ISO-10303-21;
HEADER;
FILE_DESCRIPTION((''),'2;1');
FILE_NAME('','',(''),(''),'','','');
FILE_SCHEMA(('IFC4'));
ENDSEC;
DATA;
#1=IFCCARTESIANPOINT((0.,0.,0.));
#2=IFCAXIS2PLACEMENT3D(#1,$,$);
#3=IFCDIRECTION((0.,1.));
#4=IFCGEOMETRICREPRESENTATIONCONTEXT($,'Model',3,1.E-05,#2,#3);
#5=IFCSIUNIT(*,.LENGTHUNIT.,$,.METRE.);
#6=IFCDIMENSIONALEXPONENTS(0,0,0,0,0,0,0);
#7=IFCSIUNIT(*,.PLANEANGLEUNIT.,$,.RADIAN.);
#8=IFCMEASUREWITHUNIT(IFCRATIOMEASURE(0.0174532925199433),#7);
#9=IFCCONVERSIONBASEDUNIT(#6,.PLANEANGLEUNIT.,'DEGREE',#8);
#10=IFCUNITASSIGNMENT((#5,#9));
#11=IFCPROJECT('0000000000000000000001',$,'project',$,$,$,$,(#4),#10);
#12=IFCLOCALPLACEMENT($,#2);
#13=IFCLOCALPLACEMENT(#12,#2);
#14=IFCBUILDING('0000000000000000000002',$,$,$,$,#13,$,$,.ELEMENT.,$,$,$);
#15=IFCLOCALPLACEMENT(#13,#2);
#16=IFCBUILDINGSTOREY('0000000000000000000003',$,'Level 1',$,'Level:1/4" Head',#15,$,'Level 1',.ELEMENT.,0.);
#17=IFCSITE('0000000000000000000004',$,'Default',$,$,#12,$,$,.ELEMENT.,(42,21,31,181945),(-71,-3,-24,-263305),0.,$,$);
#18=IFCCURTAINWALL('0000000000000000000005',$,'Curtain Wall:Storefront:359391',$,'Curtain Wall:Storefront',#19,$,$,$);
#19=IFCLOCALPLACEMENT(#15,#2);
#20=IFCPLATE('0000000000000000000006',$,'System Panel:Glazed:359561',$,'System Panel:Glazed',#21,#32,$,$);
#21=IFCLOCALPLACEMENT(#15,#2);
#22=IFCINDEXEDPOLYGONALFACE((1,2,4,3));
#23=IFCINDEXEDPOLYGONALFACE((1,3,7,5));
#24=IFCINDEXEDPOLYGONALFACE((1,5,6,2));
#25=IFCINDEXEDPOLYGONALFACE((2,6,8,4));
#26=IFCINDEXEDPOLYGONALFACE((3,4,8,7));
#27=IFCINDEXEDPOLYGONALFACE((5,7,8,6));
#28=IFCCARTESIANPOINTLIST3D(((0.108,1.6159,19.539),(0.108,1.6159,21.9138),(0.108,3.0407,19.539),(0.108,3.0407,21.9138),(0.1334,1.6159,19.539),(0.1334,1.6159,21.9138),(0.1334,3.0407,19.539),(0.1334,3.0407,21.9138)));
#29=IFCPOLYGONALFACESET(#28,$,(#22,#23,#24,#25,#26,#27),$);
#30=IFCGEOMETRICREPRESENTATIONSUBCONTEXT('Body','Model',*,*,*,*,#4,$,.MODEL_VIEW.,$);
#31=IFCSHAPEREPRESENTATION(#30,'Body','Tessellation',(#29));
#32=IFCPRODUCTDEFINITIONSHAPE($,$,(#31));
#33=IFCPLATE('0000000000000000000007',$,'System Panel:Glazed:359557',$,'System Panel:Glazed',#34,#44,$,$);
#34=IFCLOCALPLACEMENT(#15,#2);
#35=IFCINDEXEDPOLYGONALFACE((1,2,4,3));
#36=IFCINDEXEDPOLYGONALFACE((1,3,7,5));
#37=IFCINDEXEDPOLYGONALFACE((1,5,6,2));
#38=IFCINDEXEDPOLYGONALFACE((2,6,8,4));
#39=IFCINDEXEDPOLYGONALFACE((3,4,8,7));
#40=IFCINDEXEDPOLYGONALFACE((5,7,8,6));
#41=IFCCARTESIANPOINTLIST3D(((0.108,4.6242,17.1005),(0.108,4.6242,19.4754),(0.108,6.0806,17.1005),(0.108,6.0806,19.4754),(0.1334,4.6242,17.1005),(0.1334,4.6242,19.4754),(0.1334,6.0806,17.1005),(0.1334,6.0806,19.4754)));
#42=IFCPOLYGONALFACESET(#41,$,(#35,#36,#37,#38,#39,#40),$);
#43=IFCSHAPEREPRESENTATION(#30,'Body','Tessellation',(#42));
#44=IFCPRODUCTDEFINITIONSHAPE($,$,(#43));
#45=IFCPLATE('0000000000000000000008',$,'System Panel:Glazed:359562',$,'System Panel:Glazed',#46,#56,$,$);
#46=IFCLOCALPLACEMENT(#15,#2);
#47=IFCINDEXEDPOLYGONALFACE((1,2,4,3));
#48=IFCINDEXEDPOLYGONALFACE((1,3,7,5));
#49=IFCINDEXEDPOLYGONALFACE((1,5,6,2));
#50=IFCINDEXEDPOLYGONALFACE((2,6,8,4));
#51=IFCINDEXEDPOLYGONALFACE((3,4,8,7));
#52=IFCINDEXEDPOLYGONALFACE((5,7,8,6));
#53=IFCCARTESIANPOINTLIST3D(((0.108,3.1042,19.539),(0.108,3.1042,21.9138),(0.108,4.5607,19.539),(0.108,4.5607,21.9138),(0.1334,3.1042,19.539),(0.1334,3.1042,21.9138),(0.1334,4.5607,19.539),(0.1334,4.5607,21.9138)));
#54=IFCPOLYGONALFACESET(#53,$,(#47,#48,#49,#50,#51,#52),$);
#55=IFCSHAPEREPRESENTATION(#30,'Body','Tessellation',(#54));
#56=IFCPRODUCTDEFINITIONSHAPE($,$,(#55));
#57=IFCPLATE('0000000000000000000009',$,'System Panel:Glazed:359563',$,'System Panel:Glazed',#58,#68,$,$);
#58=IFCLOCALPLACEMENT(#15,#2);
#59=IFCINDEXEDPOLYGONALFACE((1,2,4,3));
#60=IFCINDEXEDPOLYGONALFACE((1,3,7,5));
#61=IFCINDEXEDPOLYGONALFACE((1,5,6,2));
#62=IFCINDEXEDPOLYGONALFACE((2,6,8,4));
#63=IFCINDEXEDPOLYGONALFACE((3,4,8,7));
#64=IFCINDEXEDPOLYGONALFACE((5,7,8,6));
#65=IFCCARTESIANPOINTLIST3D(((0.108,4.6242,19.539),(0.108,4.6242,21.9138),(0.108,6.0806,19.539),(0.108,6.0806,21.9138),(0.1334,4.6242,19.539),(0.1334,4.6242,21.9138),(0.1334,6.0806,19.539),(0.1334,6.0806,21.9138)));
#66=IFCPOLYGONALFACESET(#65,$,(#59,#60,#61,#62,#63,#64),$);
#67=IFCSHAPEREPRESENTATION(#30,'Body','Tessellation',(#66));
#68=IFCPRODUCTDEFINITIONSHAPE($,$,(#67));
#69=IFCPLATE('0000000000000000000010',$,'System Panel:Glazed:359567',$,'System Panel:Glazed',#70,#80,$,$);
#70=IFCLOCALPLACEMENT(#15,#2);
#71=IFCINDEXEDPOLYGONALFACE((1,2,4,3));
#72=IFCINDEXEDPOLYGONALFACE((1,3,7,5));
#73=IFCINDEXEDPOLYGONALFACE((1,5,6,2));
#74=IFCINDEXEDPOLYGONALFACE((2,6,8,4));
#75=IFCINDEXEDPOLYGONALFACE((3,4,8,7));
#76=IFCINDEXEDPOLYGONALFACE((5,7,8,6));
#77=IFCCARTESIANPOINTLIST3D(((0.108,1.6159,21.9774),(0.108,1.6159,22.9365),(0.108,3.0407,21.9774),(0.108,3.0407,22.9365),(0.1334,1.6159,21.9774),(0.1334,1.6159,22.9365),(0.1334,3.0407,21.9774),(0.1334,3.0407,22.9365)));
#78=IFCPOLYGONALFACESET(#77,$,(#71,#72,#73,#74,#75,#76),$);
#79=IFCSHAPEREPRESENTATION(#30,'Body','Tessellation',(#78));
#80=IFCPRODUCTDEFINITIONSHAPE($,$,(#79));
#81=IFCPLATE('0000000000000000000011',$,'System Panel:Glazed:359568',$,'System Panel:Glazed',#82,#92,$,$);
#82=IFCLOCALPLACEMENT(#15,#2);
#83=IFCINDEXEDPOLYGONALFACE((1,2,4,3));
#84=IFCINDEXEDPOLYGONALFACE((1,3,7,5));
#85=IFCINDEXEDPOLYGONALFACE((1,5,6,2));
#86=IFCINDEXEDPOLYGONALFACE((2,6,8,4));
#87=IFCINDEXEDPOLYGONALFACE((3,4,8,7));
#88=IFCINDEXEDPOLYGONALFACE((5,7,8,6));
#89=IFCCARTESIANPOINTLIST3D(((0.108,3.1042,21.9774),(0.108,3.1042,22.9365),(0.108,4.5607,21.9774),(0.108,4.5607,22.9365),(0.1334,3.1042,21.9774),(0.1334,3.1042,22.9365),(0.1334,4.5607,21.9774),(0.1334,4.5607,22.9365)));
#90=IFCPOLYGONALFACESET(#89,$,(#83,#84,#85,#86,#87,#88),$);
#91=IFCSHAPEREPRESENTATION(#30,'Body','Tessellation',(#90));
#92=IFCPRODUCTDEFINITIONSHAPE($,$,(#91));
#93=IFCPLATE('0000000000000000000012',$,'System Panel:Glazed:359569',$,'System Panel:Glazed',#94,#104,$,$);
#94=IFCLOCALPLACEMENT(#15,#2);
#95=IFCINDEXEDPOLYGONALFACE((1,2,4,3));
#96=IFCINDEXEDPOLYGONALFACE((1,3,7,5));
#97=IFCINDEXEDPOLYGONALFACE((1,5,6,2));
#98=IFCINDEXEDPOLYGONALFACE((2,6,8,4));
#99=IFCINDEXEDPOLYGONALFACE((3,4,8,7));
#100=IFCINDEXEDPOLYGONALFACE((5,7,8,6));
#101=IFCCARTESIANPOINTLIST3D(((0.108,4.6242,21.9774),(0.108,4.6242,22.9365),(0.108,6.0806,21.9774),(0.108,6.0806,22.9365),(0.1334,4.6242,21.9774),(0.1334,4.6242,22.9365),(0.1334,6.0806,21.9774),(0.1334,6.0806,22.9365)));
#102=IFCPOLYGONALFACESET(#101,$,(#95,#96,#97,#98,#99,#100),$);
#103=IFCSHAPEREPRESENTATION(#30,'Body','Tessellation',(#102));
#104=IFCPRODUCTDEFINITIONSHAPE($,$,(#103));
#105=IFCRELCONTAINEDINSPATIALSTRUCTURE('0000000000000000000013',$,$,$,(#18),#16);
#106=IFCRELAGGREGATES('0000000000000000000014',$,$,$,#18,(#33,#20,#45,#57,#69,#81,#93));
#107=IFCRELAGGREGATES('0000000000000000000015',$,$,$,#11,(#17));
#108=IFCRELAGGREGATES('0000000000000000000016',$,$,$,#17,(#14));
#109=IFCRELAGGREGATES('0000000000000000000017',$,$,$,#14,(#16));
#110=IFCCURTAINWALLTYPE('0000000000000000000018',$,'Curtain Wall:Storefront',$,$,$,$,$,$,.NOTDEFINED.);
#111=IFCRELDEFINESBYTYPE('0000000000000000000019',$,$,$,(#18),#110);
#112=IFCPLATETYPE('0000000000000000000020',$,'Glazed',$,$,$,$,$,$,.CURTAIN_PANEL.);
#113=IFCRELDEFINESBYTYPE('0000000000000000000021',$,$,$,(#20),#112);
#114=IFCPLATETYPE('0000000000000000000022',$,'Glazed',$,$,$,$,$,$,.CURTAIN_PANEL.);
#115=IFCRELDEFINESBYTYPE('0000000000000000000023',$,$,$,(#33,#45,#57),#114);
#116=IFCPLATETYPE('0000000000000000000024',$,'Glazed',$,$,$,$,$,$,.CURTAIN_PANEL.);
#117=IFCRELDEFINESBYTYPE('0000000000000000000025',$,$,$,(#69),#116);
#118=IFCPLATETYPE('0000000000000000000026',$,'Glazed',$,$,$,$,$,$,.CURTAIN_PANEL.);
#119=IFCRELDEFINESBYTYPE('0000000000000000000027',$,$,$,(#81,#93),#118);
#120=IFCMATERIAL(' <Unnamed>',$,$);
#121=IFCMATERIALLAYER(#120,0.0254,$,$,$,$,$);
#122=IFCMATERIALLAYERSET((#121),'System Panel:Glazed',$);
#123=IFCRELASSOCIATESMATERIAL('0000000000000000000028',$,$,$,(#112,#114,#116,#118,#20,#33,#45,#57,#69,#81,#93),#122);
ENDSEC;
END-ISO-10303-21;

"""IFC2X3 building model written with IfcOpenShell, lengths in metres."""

from ifc_helpers import new_model, entity, si_unit, converted_unit, direction, frame, frame_2d, origin, place, context, subcontext, project, spatial, rectangle, extrude, source, transform, mapped, material, layer, layer_set, layer_usage, type_object, type_shapes, element, aggregate, save


model = new_model("IFC2X3")

# Units and contexts
model_context = context("Model", 3, precision=1e-05, world=origin(), true_north=direction((0.0, 1.0)))
body_context = subcontext(model_context, "Body", "Model", "MODEL_VIEW")
ifc_project = project(units=[si_unit("LENGTHUNIT", "METRE"), converted_unit("PLANEANGLEUNIT", "DEGREE", entity("IfcRatioMeasure", 0.0174532925199433), si_unit("PLANEANGLEUNIT", "RADIAN"), dimensions=[0, 0, 0, 0, 0, 0, 0])], contexts=[model_context])

# Site, building, storey
site_placement = place(None, origin())
site = spatial("IfcSite", under=ifc_project, at=site_placement, Name="Default", CompositionType="ELEMENT", RefLatitude=(42, 21, 31, 181945), RefLongitude=(-71, -3, -24, -263305), RefElevation=0.0)
building_placement = place(site_placement, origin())
building = spatial("IfcBuilding", under=site, at=building_placement, CompositionType="ELEMENT")
storey_placement = place(building_placement, origin())
storey = spatial("IfcBuildingStorey", under=building, at=storey_placement, Name="Level 1", ObjectType="Level:1/4\" Head", LongName="Level 1", CompositionType="ELEMENT", Elevation=0.0)

# Curtain wall, plates
curtain_wall_type = type_object("IfcCurtainWallType", Name="Curtain Wall:Storefront", PredefinedType="NOTDEFINED")
curtain_wall_placement = place(storey_placement, origin())
curtain_wall = element("IfcCurtainWall", 1, at=curtain_wall_placement, inside=storey, type_object=curtain_wall_type, Name="Curtain Wall:Storefront:359391", ObjectType="Curtain Wall:Storefront")
ifc_material_1 = material(Name=" <Unnamed>")
ifc_layer = layer(ifc_material_1, 0.0254)
ifc_layer_set = layer_set([ifc_layer], Name="System Panel:Glazed")
ifc_layer_usage_1 = layer_usage(ifc_layer_set, "AXIS3", "POSITIVE", 0.1042)
plate_type_1 = type_object("IfcPlateType", Name="Glazed", PredefinedType="CURTAIN_PANEL", material=ifc_layer_set)
shared_shape_1 = source(origin(), body_context, "Body", "SweptSolid", [
    extrude(rectangle(XDim=0.0254, YDim=1.4248, at=frame_2d((0.0, 0.0), x_axis=(1.0, 0.0))), frame((0.7124, 0.0127, 0.0), z_axis=(0.0, 0.0, 1.0), x_axis=(0.0, 1.0, 0.0)), (0.0, 0.0, 1.0), 2.3749),
])
type_shapes(plate_type_1, [shared_shape_1])
plate_1_placement = place(curtain_wall_placement, frame((0.1334, 1.6159, 19.5389), z_axis=(0.0, 0.0, 1.0), x_axis=(0.0, 1.0, 0.0)))
plate_1 = element("IfcPlate", 2, at=plate_1_placement, type_object=plate_type_1, material=ifc_layer_usage_1, Name="System Panel:Glazed:359561", ObjectType="System Panel:Glazed", context=body_context, shape_type="MappedRepresentation", body=[
    mapped(shared_shape_1, transform((0.0, 0.0, 0.0), scale=1.0)),
])
ifc_layer_usage_2 = layer_usage(ifc_layer_set, "AXIS3", "POSITIVE", 0.1042)
plate_type_2 = type_object("IfcPlateType", Name="Glazed", PredefinedType="CURTAIN_PANEL", material=ifc_layer_set)
shared_shape_2 = source(origin(), body_context, "Body", "SweptSolid", [
    extrude(rectangle(XDim=0.0254, YDim=1.4565, at=frame_2d((0.0, 0.0), x_axis=(1.0, 0.0))), frame((0.7282, 0.0127, 0.0), z_axis=(0.0, 0.0, 1.0), x_axis=(0.0, 1.0, 0.0)), (0.0, 0.0, 1.0), 2.3749),
])
type_shapes(plate_type_2, [shared_shape_2])
plate_2_placement = place(curtain_wall_placement, frame((0.1334, 4.6242, 17.1005), z_axis=(0.0, 0.0, 1.0), x_axis=(0.0, 1.0, 0.0)))
plate_2 = element("IfcPlate", 3, at=plate_2_placement, type_object=plate_type_2, material=ifc_layer_usage_2, Name="System Panel:Glazed:359557", ObjectType="System Panel:Glazed", context=body_context, shape_type="MappedRepresentation", body=[
    mapped(shared_shape_2, transform((0.0, 0.0, 0.0), scale=1.0)),
])
ifc_layer_usage_3 = layer_usage(ifc_layer_set, "AXIS3", "POSITIVE", 0.1042)
plate_3_placement = place(curtain_wall_placement, frame((0.1334, 3.1042, 19.5389), z_axis=(0.0, 0.0, 1.0), x_axis=(0.0, 1.0, 0.0)))
plate_3 = element("IfcPlate", 4, at=plate_3_placement, type_object=plate_type_2, material=ifc_layer_usage_3, Name="System Panel:Glazed:359562", ObjectType="System Panel:Glazed", context=body_context, shape_type="MappedRepresentation", body=[
    mapped(shared_shape_2, transform((0.0, 0.0, 0.0), scale=1.0)),
])
ifc_layer_usage_4 = layer_usage(ifc_layer_set, "AXIS3", "POSITIVE", 0.1042)
plate_4_placement = place(curtain_wall_placement, frame((0.1334, 4.6242, 19.5389), z_axis=(0.0, 0.0, 1.0), x_axis=(0.0, 1.0, 0.0)))
plate_4 = element("IfcPlate", 5, at=plate_4_placement, type_object=plate_type_2, material=ifc_layer_usage_4, Name="System Panel:Glazed:359563", ObjectType="System Panel:Glazed", context=body_context, shape_type="MappedRepresentation", body=[
    mapped(shared_shape_2, transform((0.0, 0.0, 0.0), scale=1.0)),
])
ifc_layer_usage_5 = layer_usage(ifc_layer_set, "AXIS3", "POSITIVE", 0.1042)
plate_type_3 = type_object("IfcPlateType", Name="Glazed", PredefinedType="CURTAIN_PANEL", material=ifc_layer_set)
shared_shape_3 = source(origin(), body_context, "Body", "SweptSolid", [
    extrude(rectangle(XDim=0.0254, YDim=1.4248, at=frame_2d((0.0, 0.0), x_axis=(1.0, 0.0))), frame((0.7124, 0.0127, 0.0), z_axis=(0.0, 0.0, 1.0), x_axis=(0.0, 1.0, 0.0)), (0.0, 0.0, 1.0), 0.9592),
])
type_shapes(plate_type_3, [shared_shape_3])
plate_5_placement = place(curtain_wall_placement, frame((0.1334, 1.6159, 21.9774), z_axis=(0.0, 0.0, 1.0), x_axis=(0.0, 1.0, 0.0)))
plate_5 = element("IfcPlate", 6, at=plate_5_placement, type_object=plate_type_3, material=ifc_layer_usage_5, Name="System Panel:Glazed:359567", ObjectType="System Panel:Glazed", context=body_context, shape_type="MappedRepresentation", body=[
    mapped(shared_shape_3, transform((0.0, 0.0, 0.0), scale=1.0)),
])
ifc_layer_usage_6 = layer_usage(ifc_layer_set, "AXIS3", "POSITIVE", 0.1042)
plate_type_4 = type_object("IfcPlateType", Name="Glazed", PredefinedType="CURTAIN_PANEL", material=ifc_layer_set)
shared_shape_4 = source(origin(), body_context, "Body", "SweptSolid", [
    extrude(rectangle(XDim=0.0254, YDim=1.4565, at=frame_2d((0.0, 0.0), x_axis=(1.0, 0.0))), frame((0.7282, 0.0127, 0.0), z_axis=(0.0, 0.0, 1.0), x_axis=(0.0, 1.0, 0.0)), (0.0, 0.0, 1.0), 0.9592),
])
type_shapes(plate_type_4, [shared_shape_4])
plate_6_placement = place(curtain_wall_placement, frame((0.1334, 3.1042, 21.9774), z_axis=(0.0, 0.0, 1.0), x_axis=(0.0, 1.0, 0.0)))
plate_6 = element("IfcPlate", 7, at=plate_6_placement, type_object=plate_type_4, material=ifc_layer_usage_6, Name="System Panel:Glazed:359568", ObjectType="System Panel:Glazed", context=body_context, shape_type="MappedRepresentation", body=[
    mapped(shared_shape_4, transform((0.0, 0.0, 0.0), scale=1.0)),
])
ifc_layer_usage_7 = layer_usage(ifc_layer_set, "AXIS3", "POSITIVE", 0.1042)
plate_7_placement = place(curtain_wall_placement, frame((0.1334, 4.6242, 21.9774), z_axis=(0.0, 0.0, 1.0), x_axis=(0.0, 1.0, 0.0)))
plate_7 = element("IfcPlate", 8, at=plate_7_placement, type_object=plate_type_4, material=ifc_layer_usage_7, Name="System Panel:Glazed:359569", ObjectType="System Panel:Glazed", context=body_context, shape_type="MappedRepresentation", body=[
    mapped(shared_shape_4, transform((0.0, 0.0, 0.0), scale=1.0)),
])
aggregate(curtain_wall, [plate_2, plate_1, plate_3, plate_4, plate_5, plate_6, plate_7])

save(model, "model.ifc")
